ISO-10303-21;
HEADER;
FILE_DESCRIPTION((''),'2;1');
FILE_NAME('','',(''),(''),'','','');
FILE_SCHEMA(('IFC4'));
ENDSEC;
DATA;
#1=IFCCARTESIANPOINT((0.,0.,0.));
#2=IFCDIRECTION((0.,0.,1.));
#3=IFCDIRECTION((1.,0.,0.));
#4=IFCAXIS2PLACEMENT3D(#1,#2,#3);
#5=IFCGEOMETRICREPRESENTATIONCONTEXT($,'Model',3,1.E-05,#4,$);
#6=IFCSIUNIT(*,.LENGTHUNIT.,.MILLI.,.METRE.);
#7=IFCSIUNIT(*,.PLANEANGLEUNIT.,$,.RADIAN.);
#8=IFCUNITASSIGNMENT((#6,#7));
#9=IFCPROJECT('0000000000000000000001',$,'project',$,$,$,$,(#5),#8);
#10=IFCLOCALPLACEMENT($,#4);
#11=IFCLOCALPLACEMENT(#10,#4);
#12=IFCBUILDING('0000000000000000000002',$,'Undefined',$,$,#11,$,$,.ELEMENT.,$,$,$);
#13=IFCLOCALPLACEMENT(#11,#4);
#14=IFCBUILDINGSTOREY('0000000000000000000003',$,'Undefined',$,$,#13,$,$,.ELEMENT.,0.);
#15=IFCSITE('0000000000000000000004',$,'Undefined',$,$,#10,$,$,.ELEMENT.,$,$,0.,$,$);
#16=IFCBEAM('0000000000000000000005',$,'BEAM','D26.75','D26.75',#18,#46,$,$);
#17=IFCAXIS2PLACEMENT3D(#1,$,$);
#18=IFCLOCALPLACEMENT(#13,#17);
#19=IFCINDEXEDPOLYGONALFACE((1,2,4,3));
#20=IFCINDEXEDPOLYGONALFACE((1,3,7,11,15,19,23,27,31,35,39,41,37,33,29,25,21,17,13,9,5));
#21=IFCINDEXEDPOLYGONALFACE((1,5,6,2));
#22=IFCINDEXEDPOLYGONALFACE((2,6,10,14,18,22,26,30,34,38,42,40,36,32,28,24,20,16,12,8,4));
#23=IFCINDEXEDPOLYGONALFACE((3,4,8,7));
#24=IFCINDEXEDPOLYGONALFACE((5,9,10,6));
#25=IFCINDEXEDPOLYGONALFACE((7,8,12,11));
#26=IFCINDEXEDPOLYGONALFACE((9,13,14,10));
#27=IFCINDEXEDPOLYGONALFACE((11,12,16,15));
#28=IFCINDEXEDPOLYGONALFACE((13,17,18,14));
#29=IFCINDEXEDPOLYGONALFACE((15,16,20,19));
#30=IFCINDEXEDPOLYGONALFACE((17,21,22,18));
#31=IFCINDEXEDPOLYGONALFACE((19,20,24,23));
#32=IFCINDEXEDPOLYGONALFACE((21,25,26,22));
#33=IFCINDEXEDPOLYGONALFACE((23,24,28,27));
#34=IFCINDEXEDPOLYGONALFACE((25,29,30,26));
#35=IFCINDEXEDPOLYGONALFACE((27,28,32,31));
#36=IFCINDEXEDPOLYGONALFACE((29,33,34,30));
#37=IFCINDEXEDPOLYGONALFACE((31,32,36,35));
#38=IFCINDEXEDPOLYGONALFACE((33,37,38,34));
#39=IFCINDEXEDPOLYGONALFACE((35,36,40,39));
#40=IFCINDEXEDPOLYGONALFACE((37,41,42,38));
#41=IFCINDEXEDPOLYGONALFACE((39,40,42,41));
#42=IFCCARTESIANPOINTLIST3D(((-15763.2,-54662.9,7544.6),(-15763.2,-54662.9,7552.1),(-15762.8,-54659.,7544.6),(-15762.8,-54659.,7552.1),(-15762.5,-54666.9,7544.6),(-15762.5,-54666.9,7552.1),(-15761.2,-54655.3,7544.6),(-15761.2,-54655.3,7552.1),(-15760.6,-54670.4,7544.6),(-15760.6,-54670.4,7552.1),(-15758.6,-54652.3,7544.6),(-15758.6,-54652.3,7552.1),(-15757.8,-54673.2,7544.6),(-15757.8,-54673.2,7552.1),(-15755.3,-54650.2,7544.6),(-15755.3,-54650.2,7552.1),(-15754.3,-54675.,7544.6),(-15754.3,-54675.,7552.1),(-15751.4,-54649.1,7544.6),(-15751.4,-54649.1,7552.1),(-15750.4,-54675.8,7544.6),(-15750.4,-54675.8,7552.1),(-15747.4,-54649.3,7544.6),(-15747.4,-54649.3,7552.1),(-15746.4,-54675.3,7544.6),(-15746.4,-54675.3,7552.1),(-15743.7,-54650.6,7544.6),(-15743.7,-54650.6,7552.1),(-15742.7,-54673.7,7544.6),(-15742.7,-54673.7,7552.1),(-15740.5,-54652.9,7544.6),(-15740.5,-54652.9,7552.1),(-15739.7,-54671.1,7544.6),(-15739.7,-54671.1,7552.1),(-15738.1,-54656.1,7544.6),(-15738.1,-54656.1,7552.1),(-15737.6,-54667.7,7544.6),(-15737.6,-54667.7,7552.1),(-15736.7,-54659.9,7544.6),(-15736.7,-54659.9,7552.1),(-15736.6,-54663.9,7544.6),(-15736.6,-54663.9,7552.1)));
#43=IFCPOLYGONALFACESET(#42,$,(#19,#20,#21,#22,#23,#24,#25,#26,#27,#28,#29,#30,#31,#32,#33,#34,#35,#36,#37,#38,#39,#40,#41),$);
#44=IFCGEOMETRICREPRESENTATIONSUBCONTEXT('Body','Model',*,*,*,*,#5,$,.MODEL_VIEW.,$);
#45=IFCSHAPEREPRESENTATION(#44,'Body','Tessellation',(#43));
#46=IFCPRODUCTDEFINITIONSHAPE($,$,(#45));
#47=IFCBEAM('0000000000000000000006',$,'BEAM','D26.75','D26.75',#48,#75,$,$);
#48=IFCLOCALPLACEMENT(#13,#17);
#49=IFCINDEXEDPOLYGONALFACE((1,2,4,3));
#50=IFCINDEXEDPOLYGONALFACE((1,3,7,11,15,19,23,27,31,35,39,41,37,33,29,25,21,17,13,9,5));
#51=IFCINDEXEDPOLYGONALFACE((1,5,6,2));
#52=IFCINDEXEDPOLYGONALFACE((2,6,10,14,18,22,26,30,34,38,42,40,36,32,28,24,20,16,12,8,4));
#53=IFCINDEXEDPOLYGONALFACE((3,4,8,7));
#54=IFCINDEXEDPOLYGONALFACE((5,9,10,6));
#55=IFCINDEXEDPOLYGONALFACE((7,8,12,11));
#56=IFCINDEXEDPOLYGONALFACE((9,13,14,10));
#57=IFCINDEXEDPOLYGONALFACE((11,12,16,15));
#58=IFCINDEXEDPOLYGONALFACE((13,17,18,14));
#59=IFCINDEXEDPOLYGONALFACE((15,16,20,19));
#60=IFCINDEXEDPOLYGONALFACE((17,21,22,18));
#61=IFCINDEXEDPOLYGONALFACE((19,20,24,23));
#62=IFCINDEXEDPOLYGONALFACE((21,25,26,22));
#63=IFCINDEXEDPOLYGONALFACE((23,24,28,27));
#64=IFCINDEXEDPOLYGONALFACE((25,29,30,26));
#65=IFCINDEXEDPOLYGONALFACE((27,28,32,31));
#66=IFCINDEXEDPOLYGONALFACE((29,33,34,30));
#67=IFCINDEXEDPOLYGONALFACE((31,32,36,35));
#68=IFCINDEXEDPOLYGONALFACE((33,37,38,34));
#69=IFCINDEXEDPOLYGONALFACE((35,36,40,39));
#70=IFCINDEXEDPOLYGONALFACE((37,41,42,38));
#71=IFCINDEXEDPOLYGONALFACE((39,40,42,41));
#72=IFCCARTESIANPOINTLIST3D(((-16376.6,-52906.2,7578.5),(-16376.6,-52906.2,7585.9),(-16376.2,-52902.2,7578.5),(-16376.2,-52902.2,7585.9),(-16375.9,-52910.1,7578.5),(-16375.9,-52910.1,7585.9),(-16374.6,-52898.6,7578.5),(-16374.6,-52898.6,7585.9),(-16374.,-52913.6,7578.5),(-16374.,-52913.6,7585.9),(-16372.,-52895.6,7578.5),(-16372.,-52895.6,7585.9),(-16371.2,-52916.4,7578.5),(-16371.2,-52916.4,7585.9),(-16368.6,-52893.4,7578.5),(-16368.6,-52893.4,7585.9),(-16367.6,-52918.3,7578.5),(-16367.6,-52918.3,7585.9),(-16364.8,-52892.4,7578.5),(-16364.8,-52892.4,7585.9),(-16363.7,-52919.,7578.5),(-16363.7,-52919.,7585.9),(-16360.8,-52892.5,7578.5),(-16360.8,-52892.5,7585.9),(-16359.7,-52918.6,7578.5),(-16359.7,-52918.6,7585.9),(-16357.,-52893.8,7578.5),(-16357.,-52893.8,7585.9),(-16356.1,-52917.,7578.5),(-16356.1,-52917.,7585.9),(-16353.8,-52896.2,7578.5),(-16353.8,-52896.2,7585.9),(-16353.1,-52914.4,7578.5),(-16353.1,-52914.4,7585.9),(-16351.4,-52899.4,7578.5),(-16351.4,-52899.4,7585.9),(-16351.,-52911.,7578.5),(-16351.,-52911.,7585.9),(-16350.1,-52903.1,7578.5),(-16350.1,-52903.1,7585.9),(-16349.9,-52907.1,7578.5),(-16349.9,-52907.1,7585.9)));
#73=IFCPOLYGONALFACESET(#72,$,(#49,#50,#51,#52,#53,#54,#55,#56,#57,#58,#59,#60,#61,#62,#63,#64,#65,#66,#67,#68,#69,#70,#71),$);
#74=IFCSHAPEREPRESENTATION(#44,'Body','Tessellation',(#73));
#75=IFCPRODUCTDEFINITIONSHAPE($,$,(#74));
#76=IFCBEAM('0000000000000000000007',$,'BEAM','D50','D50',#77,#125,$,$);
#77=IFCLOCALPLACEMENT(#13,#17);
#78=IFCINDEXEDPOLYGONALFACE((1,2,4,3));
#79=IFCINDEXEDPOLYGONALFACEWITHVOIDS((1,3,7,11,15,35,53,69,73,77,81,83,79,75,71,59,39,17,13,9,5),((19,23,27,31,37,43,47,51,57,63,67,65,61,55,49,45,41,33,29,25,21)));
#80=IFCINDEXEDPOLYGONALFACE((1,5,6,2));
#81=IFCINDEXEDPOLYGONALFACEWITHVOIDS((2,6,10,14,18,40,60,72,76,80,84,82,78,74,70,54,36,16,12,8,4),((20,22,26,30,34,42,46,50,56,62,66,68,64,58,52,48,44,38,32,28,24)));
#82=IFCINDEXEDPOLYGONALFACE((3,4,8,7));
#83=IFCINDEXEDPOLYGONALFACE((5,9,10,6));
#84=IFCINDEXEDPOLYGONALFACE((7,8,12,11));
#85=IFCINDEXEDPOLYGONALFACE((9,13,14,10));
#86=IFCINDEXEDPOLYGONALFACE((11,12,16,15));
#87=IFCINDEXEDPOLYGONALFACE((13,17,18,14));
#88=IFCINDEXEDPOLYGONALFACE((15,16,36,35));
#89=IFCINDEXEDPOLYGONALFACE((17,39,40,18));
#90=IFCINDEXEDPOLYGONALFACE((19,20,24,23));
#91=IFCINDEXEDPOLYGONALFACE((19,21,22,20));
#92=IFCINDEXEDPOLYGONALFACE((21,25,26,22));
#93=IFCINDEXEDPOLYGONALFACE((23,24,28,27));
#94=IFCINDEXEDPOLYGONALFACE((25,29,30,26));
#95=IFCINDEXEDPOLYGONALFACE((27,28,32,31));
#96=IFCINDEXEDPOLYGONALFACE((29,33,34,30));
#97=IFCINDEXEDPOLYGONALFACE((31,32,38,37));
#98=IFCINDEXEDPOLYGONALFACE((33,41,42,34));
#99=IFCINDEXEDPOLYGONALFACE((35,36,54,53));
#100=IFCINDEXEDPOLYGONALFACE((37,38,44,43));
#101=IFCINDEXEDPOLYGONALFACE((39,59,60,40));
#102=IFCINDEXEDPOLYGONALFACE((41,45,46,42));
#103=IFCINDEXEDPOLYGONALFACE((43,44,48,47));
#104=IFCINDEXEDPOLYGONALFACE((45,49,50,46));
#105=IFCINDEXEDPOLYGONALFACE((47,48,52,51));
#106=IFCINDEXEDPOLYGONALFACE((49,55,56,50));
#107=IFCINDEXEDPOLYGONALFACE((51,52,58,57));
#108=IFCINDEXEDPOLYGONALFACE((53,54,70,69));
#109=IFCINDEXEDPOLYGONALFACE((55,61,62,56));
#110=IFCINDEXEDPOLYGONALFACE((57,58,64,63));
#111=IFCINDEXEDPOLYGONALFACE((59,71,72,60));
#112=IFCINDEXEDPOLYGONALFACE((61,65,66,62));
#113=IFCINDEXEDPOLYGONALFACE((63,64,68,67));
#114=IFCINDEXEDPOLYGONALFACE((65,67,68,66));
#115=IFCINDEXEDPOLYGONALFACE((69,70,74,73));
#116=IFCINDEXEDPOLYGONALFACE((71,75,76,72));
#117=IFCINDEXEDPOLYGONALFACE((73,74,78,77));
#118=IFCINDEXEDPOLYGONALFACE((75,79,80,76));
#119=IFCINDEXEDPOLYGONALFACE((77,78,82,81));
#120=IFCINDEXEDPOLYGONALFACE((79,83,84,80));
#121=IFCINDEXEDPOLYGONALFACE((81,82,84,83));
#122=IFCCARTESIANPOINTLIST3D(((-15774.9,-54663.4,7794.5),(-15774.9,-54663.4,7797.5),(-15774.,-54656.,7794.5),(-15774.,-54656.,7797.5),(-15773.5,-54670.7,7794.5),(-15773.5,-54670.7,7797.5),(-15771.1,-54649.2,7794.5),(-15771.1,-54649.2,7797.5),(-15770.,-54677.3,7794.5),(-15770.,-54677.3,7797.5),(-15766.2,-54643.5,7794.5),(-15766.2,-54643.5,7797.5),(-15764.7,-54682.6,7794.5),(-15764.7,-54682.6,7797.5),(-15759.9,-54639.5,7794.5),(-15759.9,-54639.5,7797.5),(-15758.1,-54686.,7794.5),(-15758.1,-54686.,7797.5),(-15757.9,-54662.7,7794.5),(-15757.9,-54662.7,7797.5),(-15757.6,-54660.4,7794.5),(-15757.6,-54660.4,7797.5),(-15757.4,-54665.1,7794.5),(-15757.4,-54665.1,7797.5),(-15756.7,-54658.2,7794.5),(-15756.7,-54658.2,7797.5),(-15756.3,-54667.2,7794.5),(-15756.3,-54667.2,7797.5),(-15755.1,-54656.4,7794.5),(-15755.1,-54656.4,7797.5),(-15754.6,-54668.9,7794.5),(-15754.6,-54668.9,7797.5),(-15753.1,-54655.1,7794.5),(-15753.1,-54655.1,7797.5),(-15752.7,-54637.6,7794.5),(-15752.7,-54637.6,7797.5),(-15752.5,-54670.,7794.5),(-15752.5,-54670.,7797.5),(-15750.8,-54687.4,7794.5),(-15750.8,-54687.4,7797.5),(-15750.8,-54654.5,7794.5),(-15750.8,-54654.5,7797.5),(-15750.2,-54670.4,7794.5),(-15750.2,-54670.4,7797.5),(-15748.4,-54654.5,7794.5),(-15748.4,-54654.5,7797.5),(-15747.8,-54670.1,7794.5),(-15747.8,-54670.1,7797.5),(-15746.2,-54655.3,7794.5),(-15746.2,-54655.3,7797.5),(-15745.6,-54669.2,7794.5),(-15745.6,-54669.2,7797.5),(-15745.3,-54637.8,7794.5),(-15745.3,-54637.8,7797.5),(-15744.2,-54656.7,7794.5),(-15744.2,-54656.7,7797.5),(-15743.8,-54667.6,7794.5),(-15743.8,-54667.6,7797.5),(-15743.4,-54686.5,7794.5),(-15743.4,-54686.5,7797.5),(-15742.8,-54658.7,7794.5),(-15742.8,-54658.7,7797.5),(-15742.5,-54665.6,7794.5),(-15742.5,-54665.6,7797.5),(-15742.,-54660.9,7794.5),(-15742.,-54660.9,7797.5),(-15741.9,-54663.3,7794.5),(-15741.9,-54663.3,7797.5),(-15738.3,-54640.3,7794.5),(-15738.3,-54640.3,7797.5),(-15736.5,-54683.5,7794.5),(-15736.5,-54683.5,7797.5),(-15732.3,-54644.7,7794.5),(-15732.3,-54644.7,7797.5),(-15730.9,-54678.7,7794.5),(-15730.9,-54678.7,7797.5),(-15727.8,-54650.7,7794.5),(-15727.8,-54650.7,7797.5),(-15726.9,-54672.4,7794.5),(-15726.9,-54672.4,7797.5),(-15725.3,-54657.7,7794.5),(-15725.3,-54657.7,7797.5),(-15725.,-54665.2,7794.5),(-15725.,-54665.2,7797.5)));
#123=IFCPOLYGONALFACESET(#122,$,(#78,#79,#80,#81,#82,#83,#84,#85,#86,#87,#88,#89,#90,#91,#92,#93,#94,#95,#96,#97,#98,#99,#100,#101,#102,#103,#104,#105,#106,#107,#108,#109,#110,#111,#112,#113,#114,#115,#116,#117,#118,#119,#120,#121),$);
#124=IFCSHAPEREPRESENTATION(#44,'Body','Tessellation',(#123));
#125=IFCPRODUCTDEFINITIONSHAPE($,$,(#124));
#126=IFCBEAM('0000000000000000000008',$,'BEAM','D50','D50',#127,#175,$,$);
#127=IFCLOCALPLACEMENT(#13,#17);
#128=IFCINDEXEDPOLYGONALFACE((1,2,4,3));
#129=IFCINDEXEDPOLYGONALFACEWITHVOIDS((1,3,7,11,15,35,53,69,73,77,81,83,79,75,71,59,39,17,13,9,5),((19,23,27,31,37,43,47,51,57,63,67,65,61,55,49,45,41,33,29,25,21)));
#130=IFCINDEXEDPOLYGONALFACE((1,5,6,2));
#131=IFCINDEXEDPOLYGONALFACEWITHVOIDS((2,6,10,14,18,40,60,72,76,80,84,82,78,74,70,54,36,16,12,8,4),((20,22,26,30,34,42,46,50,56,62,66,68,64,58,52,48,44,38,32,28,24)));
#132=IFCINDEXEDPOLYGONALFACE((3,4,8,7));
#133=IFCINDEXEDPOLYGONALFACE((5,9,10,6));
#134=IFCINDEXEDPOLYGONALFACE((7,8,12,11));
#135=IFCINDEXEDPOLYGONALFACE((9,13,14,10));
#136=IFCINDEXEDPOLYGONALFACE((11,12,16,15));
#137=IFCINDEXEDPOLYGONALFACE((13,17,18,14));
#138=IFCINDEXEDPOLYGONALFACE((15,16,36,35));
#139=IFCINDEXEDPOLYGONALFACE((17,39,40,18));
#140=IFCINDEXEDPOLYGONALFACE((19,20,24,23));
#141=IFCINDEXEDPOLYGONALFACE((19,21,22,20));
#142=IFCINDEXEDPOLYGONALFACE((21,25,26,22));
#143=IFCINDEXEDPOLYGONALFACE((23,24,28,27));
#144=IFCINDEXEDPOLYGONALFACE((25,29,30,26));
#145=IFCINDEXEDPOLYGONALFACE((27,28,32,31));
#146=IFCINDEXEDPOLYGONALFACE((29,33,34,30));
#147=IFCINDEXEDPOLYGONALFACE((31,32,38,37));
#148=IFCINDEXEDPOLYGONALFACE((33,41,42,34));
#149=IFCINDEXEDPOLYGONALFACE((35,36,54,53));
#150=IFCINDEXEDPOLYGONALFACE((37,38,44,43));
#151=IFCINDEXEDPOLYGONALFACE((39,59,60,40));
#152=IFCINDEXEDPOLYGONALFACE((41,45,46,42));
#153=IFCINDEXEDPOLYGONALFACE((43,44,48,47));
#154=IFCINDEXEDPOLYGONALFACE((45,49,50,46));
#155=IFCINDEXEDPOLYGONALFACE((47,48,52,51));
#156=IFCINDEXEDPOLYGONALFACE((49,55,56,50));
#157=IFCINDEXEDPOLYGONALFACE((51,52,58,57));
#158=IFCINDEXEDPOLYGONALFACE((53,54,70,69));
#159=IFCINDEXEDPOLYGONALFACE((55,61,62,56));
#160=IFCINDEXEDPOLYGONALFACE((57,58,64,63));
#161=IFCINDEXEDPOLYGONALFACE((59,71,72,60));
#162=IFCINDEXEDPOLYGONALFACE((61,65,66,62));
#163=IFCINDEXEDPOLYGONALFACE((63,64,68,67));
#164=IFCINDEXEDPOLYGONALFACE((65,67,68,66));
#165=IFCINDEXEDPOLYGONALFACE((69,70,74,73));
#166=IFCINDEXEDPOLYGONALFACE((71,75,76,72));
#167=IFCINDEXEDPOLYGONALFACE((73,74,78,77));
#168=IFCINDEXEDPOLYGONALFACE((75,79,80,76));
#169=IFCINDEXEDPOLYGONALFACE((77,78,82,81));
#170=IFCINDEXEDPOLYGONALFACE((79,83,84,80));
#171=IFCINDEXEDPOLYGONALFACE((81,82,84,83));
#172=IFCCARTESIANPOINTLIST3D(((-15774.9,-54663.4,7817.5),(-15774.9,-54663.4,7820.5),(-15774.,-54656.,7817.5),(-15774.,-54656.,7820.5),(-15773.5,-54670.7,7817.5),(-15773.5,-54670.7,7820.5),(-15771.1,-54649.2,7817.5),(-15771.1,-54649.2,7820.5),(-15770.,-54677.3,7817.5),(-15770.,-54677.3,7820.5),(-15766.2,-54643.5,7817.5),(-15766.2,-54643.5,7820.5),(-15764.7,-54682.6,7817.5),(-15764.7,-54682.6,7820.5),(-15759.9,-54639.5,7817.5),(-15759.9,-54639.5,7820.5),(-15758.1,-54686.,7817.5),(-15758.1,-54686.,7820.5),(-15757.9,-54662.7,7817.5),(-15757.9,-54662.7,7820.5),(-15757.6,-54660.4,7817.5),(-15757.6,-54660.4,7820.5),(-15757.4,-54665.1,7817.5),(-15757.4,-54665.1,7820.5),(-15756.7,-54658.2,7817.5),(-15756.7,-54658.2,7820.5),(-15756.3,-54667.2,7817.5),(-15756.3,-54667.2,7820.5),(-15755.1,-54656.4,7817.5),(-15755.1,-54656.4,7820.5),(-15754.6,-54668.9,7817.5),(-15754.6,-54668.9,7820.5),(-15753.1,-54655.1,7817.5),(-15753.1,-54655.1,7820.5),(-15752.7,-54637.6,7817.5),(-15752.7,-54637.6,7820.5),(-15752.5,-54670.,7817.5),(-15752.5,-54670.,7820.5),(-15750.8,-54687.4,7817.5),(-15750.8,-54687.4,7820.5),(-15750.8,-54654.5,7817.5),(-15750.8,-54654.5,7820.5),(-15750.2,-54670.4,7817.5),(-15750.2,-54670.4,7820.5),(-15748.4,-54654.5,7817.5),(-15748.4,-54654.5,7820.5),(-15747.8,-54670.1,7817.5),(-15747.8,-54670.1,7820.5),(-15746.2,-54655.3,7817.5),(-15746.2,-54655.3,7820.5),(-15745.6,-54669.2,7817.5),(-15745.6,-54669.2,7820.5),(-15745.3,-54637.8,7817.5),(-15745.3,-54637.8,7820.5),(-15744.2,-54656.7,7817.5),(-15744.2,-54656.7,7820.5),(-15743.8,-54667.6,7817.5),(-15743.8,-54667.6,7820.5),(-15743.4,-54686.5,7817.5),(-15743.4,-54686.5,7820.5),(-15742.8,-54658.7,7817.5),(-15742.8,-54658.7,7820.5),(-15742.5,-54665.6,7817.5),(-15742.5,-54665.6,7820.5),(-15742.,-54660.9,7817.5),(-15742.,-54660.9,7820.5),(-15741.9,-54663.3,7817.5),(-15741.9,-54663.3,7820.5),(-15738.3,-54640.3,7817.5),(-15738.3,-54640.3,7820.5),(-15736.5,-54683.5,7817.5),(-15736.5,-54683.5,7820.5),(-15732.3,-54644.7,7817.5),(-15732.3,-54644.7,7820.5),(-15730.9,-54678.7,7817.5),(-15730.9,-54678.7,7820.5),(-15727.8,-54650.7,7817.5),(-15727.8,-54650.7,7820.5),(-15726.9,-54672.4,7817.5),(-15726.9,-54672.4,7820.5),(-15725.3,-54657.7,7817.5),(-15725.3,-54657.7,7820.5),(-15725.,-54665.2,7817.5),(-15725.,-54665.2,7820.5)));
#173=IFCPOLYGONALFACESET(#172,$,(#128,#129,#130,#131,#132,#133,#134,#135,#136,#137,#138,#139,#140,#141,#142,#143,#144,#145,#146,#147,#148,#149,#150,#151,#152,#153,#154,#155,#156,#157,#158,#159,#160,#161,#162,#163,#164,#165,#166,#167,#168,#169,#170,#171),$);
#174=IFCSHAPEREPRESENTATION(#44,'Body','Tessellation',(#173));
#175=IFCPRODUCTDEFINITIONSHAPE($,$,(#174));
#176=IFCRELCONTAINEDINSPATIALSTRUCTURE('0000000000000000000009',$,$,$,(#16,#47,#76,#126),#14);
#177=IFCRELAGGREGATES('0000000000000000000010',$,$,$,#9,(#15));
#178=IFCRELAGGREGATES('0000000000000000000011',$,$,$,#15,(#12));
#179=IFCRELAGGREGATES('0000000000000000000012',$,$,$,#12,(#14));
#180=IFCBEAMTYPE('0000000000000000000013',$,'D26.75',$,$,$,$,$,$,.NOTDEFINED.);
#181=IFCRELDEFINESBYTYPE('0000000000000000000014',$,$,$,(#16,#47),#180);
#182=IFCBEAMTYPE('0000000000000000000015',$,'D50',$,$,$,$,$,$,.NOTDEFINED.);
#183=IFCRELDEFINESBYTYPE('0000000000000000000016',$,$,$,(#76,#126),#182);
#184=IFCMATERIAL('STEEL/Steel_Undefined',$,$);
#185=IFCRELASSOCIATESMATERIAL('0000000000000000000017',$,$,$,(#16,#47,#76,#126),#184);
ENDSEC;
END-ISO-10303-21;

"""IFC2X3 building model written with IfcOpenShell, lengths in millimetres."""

from ifc_helpers import new_model, si_unit, frame, origin_with_axes, origin_2d_with_axis, place, context, subcontext, project, spatial, circle, extrude, material, type_object, element, save


model = new_model("IFC2X3")

# Units and contexts
model_context = context("Model", 3, precision=1e-05, world=origin_with_axes())
body_context = subcontext(model_context, "Body", "Model", "MODEL_VIEW")
ifc_project = project(units=[si_unit("LENGTHUNIT", "METRE", prefix="MILLI"), si_unit("PLANEANGLEUNIT", "RADIAN")], contexts=[model_context])

# Site, building, storey
site_placement = place(None, origin_with_axes())
site = spatial("IfcSite", under=ifc_project, at=site_placement, Name="Undefined", CompositionType="ELEMENT", RefElevation=0.0)
building_placement = place(site_placement, origin_with_axes())
building = spatial("IfcBuilding", under=site, at=building_placement, Name="Undefined", CompositionType="ELEMENT")
storey_placement = place(building_placement, origin_with_axes())
storey = spatial("IfcBuildingStorey", under=building, at=storey_placement, Name="Undefined", CompositionType="ELEMENT", Elevation=0.0)

# Shared definitions
ifc_material = material(Name="STEEL/Steel_Undefined")
beam_type_1 = type_object("IfcBeamType", Name="D26.75", PredefinedType="NOTDEFINED")

# Beams
for number, where, z_axis, x_axis, name in (
    (1, (-15749.9, -54662.4, 7552.1), (-0.915553, -0.402197, 0.0), (0.0, 0.0, -1.0), "BEAM"),
    (2, (-16363.2, -52905.7, 7585.9), (-0.915553, -0.402197, 0.0), (0.0, 0.0, -1.0), "BEAM"),
):
    element("IfcBeam", number, at=place(storey_placement, frame(where, z_axis=z_axis, x_axis=x_axis)), inside=storey, type_object=beam_type_1, material=ifc_material, Name=name, Description="D26.75", ObjectType="D26.75", context=body_context, shape_type="SweptSolid", body=[
        extrude(circle(Radius=13.4, at=origin_2d_with_axis()), frame((7.4, 0.0, 0.0), z_axis=(-1.0, 0.0, 0.0), x_axis=(0.0, -1.0, 0.0)), (0.0, 0.0, 1.0), 7.4),
    ])

# Beams, openings
beam_type_2 = type_object("IfcBeamType", Name="D50", PredefinedType="NOTDEFINED")
beam_1_placement = place(storey_placement, frame((-15749.9, -54662.4, 7797.5), z_axis=(-0.915553, -0.402197, 0.0), x_axis=(0.0, 0.0, -1.0)))
beam_1 = element("IfcBeam", 3, at=beam_1_placement, inside=storey, type_object=beam_type_2, material=ifc_material, Name="BEAM", Description="D50", ObjectType="D50", context=body_context, shape_type="SweptSolid", body=[
    extrude(circle(Radius=25.0, at=origin_2d_with_axis()), frame((3.0, 0.0, 0.0), z_axis=(-1.0, 0.0, 0.0), x_axis=(0.0, -1.0, 0.0)), (0.0, 0.0, 1.0), 3.0),
])
opening_1_placement = place(storey_placement, frame((-15749.9, -54662.4, 7797.5), z_axis=(-0.915553, -0.402197, 0.0), x_axis=(0.0, 0.0, -1.0)))
element("IfcOpeningElement", 4, at=opening_1_placement, cuts=beam_1, ObjectType="Recess", context=body_context, shape_type="SweptSolid", body=[
    extrude(circle(Radius=8.0, at=origin_2d_with_axis()), frame((245.5, 0.0, 0.0), z_axis=(-1.0, 0.0, 0.0), x_axis=(0.0, -1.0, 0.0)), (0.0, 0.0, 1.0), 292.6),
])
beam_2_placement = place(storey_placement, frame((-15749.9, -54662.4, 7820.5), z_axis=(-0.915553, -0.402197, 0.0), x_axis=(0.0, 0.0, -1.0)))
beam_2 = element("IfcBeam", 5, at=beam_2_placement, inside=storey, type_object=beam_type_2, material=ifc_material, Name="BEAM", Description="D50", ObjectType="D50", context=body_context, shape_type="SweptSolid", body=[
    extrude(circle(Radius=25.0, at=origin_2d_with_axis()), frame((3.0, 0.0, 0.0), z_axis=(-1.0, 0.0, 0.0), x_axis=(0.0, -1.0, 0.0)), (0.0, 0.0, 1.0), 3.0),
])
opening_2_placement = place(storey_placement, frame((-15749.9, -54662.4, 7820.5), z_axis=(-0.915553, -0.402197, 0.0), x_axis=(0.0, 0.0, -1.0)))
element("IfcOpeningElement", 6, at=opening_2_placement, cuts=beam_2, ObjectType="Recess", context=body_context, shape_type="SweptSolid", body=[
    extrude(circle(Radius=8.0, at=origin_2d_with_axis()), frame((268.5, 0.0, 0.0), z_axis=(-1.0, 0.0, 0.0), x_axis=(0.0, -1.0, 0.0)), (0.0, 0.0, 1.0), 292.6),
])

save(model, "model.ifc")
